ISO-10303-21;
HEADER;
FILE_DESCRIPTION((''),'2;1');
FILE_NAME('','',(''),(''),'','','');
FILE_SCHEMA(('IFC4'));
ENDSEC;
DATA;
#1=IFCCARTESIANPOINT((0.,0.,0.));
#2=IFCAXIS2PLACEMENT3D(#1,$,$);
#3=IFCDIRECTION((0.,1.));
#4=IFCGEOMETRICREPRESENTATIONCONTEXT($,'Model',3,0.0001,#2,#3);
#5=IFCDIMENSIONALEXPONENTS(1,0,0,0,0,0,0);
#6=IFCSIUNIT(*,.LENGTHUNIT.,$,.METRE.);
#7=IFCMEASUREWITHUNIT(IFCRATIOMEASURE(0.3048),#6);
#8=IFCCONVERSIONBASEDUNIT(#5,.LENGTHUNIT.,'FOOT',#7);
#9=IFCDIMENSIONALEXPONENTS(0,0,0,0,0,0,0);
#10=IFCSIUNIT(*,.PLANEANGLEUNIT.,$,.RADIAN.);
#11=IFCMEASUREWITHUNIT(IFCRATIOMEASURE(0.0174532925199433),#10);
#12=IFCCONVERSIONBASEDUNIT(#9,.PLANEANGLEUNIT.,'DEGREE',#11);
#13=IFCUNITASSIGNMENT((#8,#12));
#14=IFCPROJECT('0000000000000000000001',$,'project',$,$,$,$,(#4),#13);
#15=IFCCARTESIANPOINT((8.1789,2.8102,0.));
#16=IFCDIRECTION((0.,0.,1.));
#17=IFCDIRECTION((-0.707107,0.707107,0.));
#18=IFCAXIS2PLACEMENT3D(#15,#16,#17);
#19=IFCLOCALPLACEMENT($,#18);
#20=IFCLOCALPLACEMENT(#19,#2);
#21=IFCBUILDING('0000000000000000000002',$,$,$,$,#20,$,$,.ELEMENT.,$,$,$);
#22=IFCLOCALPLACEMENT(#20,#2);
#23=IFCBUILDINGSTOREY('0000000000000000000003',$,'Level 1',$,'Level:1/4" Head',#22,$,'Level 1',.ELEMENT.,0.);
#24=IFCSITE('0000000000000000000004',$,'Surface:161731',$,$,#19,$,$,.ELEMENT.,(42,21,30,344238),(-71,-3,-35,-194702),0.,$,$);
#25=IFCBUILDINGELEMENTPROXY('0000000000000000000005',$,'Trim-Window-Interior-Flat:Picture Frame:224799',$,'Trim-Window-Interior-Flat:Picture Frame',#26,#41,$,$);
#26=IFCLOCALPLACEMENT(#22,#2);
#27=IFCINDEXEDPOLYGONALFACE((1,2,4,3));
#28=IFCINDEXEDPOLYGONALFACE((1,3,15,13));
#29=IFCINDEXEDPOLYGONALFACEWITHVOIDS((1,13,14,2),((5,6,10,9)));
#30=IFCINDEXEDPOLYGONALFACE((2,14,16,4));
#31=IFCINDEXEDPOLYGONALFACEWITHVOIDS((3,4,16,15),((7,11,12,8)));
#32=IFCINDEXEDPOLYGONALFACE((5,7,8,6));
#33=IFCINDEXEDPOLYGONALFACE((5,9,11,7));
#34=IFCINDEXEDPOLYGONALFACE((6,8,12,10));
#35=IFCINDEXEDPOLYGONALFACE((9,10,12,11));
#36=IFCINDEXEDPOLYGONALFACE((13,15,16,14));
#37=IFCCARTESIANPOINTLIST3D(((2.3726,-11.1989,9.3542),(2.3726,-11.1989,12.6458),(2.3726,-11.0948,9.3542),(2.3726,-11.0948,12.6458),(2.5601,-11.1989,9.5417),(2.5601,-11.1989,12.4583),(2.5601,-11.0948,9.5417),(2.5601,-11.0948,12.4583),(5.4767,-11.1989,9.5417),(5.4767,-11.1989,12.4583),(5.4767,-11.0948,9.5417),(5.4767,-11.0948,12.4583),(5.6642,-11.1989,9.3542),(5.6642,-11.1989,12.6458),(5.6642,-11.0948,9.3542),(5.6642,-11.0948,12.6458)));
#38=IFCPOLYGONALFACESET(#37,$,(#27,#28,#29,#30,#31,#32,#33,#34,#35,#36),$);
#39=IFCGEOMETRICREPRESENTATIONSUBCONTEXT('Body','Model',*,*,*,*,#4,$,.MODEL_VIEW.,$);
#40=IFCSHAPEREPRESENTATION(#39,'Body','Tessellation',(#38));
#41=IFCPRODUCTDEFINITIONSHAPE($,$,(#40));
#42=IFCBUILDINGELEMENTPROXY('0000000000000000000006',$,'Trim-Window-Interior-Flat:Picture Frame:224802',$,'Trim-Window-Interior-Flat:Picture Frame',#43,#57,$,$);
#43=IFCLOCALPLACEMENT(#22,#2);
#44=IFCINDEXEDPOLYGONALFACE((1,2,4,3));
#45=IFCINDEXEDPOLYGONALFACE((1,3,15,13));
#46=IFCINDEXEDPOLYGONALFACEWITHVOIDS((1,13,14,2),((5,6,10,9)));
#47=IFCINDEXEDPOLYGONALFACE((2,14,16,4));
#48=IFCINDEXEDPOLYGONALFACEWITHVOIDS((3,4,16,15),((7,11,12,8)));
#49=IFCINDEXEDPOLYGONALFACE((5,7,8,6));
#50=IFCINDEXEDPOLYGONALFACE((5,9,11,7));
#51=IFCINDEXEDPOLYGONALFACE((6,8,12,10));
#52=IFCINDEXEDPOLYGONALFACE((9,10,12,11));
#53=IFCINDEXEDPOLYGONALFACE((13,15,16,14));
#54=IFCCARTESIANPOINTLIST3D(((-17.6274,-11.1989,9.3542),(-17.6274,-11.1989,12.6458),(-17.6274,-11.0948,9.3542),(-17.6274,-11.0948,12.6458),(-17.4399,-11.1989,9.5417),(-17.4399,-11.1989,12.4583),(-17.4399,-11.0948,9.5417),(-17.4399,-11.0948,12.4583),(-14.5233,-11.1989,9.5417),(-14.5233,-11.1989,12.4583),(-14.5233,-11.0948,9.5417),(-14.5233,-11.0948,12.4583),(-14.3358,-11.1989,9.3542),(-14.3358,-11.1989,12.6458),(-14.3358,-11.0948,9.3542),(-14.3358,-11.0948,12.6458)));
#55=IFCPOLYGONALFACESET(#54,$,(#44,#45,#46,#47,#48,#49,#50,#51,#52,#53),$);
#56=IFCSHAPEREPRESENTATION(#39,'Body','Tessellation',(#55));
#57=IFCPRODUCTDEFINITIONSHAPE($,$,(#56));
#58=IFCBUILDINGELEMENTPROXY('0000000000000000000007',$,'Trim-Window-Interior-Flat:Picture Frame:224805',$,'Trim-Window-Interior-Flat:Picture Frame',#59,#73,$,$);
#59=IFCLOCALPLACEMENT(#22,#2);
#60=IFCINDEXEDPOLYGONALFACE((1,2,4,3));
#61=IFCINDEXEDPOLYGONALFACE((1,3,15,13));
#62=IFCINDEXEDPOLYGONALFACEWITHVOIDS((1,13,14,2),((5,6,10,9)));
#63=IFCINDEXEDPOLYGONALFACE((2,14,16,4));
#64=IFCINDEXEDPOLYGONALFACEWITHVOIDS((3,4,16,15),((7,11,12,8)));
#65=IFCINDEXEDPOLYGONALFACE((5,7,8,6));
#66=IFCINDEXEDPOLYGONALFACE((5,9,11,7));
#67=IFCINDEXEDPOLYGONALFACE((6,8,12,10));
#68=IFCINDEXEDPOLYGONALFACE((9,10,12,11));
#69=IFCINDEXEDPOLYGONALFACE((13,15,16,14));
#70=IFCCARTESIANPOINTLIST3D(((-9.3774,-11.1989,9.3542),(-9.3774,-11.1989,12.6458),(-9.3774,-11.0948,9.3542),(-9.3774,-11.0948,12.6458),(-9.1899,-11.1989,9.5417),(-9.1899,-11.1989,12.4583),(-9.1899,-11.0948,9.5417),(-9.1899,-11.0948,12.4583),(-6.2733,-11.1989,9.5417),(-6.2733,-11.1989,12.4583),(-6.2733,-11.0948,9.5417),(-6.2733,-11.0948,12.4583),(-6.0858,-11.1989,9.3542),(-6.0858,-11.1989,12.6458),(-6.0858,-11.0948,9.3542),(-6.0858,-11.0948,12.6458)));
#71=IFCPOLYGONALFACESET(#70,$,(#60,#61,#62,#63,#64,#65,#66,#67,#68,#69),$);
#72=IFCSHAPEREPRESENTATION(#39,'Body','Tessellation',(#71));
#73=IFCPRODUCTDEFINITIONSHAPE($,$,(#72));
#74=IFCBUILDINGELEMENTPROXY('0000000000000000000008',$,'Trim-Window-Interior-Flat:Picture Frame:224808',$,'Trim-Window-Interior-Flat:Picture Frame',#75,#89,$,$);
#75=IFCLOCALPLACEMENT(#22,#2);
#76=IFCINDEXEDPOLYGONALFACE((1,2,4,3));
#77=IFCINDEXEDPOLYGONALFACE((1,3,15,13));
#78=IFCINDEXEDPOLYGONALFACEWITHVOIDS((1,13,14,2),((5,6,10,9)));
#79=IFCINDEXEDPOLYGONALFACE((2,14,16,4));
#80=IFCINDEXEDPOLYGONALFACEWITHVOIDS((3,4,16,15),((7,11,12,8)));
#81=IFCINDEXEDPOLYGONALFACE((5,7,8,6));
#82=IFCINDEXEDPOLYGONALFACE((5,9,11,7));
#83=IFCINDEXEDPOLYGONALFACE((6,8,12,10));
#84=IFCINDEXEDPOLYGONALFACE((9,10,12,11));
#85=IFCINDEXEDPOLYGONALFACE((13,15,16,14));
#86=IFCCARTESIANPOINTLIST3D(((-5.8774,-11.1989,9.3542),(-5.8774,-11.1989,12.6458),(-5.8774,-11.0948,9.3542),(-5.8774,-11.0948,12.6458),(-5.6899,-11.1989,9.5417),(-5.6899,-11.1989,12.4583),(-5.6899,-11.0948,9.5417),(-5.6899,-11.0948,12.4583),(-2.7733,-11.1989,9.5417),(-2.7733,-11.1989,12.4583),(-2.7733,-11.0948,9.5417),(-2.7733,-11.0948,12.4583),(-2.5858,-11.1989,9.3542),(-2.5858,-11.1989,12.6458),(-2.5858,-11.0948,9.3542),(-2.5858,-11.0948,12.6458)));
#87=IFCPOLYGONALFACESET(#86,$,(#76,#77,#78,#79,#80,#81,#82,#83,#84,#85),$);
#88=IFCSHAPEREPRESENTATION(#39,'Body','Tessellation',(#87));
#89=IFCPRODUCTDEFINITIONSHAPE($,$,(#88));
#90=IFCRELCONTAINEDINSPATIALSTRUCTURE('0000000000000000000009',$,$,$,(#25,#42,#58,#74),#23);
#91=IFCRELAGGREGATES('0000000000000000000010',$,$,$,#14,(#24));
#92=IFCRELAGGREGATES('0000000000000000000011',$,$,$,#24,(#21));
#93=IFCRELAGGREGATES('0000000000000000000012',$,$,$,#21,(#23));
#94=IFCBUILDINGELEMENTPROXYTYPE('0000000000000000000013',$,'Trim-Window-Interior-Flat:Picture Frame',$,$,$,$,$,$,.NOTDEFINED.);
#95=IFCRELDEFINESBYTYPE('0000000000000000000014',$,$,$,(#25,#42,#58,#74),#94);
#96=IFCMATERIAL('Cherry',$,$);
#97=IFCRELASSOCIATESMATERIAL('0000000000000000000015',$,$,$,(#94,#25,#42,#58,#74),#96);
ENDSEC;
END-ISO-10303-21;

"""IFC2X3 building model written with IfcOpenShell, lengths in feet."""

from ifc_helpers import new_model, entity, si_unit, converted_unit, direction, frame, origin, place, context, subcontext, project, spatial, polyline, outline, extrude, source, transform, mapped, material, type_object, type_shapes, element, save


model = new_model("IFC2X3")

# Units and contexts
model_context = context("Model", 3, precision=0.0001, world=origin(), true_north=direction((0.0, 1.0)))
body_context = subcontext(model_context, "Body", "Model", "MODEL_VIEW")
ifc_project = project(units=[converted_unit("LENGTHUNIT", "FOOT", entity("IfcRatioMeasure", 0.3048), si_unit("LENGTHUNIT", "METRE"), dimensions=[1, 0, 0, 0, 0, 0, 0]), converted_unit("PLANEANGLEUNIT", "DEGREE", entity("IfcRatioMeasure", 0.0174532925199433), si_unit("PLANEANGLEUNIT", "RADIAN"), dimensions=[0, 0, 0, 0, 0, 0, 0])], contexts=[model_context])

# Site, building, storey
site_placement = place(None, frame((8.1789, 2.8102, 0.0), z_axis=(0.0, 0.0, 1.0), x_axis=(-0.707107, 0.707107, 0.0)))
site = spatial("IfcSite", under=ifc_project, at=site_placement, Name="Surface:161731", CompositionType="ELEMENT", RefLatitude=(42, 21, 30, 344238), RefLongitude=(-71, -3, -35, -194702), RefElevation=0.0)
building_placement = place(site_placement, origin())
building = spatial("IfcBuilding", under=site, at=building_placement, CompositionType="ELEMENT")
storey_placement = place(building_placement, origin())
storey = spatial("IfcBuildingStorey", under=building, at=storey_placement, Name="Level 1", ObjectType="Level:1/4\" Head", LongName="Level 1", CompositionType="ELEMENT", Elevation=0.0)

# Building element proxies
ifc_material_1 = material(Name="Cherry")
building_element_proxy_type_1 = type_object("IfcBuildingElementProxyType", Name="Trim-Window-Interior-Flat:Picture Frame", PredefinedType="NOTDEFINED", material=ifc_material_1)
shared_shape_1 = source(origin(), body_context, "Body", "SweptSolid", [
    extrude(outline(polyline([(-1.6458, -1.6458), (1.6458, -1.6458), (1.6458, 1.6458), (-1.6458, 1.6458), (-1.6458, -1.6458)]), holes=[polyline([(-1.4583, -1.4583), (-1.4583, 1.4583), (1.4583, 1.4583), (1.4583, -1.4583), (-1.4583, -1.4583)])]), frame((0.0, -1.5, 0.0), z_axis=(0.0, 0.0, 1.0), x_axis=(-1.0, 0.0, 0.0)), (0.0, 0.0, 1.0), 0.1042),
])
type_shapes(building_element_proxy_type_1, [shared_shape_1])
for number, where, z_axis, x_axis, name in (
    (1, (4.0184, -11.1989, 12.5), (0.0, 1.0, 0.0), (-1.0, 0.0, 0.0), "Trim-Window-Interior-Flat:Picture Frame:224799"),
    (2, (-15.9816, -11.1989, 12.5), (0.0, 1.0, 0.0), (-1.0, 0.0, 0.0), "Trim-Window-Interior-Flat:Picture Frame:224802"),
    (3, (-7.7316, -11.1989, 12.5), (0.0, 1.0, 0.0), (-1.0, 0.0, 0.0), "Trim-Window-Interior-Flat:Picture Frame:224805"),
    (4, (-4.2316, -11.1989, 12.5), (0.0, 1.0, 0.0), (-1.0, 0.0, 0.0), "Trim-Window-Interior-Flat:Picture Frame:224808"),
):
    element("IfcBuildingElementProxy", number, at=place(storey_placement, frame(where, z_axis=z_axis, x_axis=x_axis)), inside=storey, type_object=building_element_proxy_type_1, material=ifc_material_1, Name=name, ObjectType="Trim-Window-Interior-Flat:Picture Frame", context=body_context, shape_type="MappedRepresentation", body=[
        mapped(shared_shape_1, transform((0.0, 0.0, 0.0), scale=1.0)),
    ])

save(model, "model.ifc")
